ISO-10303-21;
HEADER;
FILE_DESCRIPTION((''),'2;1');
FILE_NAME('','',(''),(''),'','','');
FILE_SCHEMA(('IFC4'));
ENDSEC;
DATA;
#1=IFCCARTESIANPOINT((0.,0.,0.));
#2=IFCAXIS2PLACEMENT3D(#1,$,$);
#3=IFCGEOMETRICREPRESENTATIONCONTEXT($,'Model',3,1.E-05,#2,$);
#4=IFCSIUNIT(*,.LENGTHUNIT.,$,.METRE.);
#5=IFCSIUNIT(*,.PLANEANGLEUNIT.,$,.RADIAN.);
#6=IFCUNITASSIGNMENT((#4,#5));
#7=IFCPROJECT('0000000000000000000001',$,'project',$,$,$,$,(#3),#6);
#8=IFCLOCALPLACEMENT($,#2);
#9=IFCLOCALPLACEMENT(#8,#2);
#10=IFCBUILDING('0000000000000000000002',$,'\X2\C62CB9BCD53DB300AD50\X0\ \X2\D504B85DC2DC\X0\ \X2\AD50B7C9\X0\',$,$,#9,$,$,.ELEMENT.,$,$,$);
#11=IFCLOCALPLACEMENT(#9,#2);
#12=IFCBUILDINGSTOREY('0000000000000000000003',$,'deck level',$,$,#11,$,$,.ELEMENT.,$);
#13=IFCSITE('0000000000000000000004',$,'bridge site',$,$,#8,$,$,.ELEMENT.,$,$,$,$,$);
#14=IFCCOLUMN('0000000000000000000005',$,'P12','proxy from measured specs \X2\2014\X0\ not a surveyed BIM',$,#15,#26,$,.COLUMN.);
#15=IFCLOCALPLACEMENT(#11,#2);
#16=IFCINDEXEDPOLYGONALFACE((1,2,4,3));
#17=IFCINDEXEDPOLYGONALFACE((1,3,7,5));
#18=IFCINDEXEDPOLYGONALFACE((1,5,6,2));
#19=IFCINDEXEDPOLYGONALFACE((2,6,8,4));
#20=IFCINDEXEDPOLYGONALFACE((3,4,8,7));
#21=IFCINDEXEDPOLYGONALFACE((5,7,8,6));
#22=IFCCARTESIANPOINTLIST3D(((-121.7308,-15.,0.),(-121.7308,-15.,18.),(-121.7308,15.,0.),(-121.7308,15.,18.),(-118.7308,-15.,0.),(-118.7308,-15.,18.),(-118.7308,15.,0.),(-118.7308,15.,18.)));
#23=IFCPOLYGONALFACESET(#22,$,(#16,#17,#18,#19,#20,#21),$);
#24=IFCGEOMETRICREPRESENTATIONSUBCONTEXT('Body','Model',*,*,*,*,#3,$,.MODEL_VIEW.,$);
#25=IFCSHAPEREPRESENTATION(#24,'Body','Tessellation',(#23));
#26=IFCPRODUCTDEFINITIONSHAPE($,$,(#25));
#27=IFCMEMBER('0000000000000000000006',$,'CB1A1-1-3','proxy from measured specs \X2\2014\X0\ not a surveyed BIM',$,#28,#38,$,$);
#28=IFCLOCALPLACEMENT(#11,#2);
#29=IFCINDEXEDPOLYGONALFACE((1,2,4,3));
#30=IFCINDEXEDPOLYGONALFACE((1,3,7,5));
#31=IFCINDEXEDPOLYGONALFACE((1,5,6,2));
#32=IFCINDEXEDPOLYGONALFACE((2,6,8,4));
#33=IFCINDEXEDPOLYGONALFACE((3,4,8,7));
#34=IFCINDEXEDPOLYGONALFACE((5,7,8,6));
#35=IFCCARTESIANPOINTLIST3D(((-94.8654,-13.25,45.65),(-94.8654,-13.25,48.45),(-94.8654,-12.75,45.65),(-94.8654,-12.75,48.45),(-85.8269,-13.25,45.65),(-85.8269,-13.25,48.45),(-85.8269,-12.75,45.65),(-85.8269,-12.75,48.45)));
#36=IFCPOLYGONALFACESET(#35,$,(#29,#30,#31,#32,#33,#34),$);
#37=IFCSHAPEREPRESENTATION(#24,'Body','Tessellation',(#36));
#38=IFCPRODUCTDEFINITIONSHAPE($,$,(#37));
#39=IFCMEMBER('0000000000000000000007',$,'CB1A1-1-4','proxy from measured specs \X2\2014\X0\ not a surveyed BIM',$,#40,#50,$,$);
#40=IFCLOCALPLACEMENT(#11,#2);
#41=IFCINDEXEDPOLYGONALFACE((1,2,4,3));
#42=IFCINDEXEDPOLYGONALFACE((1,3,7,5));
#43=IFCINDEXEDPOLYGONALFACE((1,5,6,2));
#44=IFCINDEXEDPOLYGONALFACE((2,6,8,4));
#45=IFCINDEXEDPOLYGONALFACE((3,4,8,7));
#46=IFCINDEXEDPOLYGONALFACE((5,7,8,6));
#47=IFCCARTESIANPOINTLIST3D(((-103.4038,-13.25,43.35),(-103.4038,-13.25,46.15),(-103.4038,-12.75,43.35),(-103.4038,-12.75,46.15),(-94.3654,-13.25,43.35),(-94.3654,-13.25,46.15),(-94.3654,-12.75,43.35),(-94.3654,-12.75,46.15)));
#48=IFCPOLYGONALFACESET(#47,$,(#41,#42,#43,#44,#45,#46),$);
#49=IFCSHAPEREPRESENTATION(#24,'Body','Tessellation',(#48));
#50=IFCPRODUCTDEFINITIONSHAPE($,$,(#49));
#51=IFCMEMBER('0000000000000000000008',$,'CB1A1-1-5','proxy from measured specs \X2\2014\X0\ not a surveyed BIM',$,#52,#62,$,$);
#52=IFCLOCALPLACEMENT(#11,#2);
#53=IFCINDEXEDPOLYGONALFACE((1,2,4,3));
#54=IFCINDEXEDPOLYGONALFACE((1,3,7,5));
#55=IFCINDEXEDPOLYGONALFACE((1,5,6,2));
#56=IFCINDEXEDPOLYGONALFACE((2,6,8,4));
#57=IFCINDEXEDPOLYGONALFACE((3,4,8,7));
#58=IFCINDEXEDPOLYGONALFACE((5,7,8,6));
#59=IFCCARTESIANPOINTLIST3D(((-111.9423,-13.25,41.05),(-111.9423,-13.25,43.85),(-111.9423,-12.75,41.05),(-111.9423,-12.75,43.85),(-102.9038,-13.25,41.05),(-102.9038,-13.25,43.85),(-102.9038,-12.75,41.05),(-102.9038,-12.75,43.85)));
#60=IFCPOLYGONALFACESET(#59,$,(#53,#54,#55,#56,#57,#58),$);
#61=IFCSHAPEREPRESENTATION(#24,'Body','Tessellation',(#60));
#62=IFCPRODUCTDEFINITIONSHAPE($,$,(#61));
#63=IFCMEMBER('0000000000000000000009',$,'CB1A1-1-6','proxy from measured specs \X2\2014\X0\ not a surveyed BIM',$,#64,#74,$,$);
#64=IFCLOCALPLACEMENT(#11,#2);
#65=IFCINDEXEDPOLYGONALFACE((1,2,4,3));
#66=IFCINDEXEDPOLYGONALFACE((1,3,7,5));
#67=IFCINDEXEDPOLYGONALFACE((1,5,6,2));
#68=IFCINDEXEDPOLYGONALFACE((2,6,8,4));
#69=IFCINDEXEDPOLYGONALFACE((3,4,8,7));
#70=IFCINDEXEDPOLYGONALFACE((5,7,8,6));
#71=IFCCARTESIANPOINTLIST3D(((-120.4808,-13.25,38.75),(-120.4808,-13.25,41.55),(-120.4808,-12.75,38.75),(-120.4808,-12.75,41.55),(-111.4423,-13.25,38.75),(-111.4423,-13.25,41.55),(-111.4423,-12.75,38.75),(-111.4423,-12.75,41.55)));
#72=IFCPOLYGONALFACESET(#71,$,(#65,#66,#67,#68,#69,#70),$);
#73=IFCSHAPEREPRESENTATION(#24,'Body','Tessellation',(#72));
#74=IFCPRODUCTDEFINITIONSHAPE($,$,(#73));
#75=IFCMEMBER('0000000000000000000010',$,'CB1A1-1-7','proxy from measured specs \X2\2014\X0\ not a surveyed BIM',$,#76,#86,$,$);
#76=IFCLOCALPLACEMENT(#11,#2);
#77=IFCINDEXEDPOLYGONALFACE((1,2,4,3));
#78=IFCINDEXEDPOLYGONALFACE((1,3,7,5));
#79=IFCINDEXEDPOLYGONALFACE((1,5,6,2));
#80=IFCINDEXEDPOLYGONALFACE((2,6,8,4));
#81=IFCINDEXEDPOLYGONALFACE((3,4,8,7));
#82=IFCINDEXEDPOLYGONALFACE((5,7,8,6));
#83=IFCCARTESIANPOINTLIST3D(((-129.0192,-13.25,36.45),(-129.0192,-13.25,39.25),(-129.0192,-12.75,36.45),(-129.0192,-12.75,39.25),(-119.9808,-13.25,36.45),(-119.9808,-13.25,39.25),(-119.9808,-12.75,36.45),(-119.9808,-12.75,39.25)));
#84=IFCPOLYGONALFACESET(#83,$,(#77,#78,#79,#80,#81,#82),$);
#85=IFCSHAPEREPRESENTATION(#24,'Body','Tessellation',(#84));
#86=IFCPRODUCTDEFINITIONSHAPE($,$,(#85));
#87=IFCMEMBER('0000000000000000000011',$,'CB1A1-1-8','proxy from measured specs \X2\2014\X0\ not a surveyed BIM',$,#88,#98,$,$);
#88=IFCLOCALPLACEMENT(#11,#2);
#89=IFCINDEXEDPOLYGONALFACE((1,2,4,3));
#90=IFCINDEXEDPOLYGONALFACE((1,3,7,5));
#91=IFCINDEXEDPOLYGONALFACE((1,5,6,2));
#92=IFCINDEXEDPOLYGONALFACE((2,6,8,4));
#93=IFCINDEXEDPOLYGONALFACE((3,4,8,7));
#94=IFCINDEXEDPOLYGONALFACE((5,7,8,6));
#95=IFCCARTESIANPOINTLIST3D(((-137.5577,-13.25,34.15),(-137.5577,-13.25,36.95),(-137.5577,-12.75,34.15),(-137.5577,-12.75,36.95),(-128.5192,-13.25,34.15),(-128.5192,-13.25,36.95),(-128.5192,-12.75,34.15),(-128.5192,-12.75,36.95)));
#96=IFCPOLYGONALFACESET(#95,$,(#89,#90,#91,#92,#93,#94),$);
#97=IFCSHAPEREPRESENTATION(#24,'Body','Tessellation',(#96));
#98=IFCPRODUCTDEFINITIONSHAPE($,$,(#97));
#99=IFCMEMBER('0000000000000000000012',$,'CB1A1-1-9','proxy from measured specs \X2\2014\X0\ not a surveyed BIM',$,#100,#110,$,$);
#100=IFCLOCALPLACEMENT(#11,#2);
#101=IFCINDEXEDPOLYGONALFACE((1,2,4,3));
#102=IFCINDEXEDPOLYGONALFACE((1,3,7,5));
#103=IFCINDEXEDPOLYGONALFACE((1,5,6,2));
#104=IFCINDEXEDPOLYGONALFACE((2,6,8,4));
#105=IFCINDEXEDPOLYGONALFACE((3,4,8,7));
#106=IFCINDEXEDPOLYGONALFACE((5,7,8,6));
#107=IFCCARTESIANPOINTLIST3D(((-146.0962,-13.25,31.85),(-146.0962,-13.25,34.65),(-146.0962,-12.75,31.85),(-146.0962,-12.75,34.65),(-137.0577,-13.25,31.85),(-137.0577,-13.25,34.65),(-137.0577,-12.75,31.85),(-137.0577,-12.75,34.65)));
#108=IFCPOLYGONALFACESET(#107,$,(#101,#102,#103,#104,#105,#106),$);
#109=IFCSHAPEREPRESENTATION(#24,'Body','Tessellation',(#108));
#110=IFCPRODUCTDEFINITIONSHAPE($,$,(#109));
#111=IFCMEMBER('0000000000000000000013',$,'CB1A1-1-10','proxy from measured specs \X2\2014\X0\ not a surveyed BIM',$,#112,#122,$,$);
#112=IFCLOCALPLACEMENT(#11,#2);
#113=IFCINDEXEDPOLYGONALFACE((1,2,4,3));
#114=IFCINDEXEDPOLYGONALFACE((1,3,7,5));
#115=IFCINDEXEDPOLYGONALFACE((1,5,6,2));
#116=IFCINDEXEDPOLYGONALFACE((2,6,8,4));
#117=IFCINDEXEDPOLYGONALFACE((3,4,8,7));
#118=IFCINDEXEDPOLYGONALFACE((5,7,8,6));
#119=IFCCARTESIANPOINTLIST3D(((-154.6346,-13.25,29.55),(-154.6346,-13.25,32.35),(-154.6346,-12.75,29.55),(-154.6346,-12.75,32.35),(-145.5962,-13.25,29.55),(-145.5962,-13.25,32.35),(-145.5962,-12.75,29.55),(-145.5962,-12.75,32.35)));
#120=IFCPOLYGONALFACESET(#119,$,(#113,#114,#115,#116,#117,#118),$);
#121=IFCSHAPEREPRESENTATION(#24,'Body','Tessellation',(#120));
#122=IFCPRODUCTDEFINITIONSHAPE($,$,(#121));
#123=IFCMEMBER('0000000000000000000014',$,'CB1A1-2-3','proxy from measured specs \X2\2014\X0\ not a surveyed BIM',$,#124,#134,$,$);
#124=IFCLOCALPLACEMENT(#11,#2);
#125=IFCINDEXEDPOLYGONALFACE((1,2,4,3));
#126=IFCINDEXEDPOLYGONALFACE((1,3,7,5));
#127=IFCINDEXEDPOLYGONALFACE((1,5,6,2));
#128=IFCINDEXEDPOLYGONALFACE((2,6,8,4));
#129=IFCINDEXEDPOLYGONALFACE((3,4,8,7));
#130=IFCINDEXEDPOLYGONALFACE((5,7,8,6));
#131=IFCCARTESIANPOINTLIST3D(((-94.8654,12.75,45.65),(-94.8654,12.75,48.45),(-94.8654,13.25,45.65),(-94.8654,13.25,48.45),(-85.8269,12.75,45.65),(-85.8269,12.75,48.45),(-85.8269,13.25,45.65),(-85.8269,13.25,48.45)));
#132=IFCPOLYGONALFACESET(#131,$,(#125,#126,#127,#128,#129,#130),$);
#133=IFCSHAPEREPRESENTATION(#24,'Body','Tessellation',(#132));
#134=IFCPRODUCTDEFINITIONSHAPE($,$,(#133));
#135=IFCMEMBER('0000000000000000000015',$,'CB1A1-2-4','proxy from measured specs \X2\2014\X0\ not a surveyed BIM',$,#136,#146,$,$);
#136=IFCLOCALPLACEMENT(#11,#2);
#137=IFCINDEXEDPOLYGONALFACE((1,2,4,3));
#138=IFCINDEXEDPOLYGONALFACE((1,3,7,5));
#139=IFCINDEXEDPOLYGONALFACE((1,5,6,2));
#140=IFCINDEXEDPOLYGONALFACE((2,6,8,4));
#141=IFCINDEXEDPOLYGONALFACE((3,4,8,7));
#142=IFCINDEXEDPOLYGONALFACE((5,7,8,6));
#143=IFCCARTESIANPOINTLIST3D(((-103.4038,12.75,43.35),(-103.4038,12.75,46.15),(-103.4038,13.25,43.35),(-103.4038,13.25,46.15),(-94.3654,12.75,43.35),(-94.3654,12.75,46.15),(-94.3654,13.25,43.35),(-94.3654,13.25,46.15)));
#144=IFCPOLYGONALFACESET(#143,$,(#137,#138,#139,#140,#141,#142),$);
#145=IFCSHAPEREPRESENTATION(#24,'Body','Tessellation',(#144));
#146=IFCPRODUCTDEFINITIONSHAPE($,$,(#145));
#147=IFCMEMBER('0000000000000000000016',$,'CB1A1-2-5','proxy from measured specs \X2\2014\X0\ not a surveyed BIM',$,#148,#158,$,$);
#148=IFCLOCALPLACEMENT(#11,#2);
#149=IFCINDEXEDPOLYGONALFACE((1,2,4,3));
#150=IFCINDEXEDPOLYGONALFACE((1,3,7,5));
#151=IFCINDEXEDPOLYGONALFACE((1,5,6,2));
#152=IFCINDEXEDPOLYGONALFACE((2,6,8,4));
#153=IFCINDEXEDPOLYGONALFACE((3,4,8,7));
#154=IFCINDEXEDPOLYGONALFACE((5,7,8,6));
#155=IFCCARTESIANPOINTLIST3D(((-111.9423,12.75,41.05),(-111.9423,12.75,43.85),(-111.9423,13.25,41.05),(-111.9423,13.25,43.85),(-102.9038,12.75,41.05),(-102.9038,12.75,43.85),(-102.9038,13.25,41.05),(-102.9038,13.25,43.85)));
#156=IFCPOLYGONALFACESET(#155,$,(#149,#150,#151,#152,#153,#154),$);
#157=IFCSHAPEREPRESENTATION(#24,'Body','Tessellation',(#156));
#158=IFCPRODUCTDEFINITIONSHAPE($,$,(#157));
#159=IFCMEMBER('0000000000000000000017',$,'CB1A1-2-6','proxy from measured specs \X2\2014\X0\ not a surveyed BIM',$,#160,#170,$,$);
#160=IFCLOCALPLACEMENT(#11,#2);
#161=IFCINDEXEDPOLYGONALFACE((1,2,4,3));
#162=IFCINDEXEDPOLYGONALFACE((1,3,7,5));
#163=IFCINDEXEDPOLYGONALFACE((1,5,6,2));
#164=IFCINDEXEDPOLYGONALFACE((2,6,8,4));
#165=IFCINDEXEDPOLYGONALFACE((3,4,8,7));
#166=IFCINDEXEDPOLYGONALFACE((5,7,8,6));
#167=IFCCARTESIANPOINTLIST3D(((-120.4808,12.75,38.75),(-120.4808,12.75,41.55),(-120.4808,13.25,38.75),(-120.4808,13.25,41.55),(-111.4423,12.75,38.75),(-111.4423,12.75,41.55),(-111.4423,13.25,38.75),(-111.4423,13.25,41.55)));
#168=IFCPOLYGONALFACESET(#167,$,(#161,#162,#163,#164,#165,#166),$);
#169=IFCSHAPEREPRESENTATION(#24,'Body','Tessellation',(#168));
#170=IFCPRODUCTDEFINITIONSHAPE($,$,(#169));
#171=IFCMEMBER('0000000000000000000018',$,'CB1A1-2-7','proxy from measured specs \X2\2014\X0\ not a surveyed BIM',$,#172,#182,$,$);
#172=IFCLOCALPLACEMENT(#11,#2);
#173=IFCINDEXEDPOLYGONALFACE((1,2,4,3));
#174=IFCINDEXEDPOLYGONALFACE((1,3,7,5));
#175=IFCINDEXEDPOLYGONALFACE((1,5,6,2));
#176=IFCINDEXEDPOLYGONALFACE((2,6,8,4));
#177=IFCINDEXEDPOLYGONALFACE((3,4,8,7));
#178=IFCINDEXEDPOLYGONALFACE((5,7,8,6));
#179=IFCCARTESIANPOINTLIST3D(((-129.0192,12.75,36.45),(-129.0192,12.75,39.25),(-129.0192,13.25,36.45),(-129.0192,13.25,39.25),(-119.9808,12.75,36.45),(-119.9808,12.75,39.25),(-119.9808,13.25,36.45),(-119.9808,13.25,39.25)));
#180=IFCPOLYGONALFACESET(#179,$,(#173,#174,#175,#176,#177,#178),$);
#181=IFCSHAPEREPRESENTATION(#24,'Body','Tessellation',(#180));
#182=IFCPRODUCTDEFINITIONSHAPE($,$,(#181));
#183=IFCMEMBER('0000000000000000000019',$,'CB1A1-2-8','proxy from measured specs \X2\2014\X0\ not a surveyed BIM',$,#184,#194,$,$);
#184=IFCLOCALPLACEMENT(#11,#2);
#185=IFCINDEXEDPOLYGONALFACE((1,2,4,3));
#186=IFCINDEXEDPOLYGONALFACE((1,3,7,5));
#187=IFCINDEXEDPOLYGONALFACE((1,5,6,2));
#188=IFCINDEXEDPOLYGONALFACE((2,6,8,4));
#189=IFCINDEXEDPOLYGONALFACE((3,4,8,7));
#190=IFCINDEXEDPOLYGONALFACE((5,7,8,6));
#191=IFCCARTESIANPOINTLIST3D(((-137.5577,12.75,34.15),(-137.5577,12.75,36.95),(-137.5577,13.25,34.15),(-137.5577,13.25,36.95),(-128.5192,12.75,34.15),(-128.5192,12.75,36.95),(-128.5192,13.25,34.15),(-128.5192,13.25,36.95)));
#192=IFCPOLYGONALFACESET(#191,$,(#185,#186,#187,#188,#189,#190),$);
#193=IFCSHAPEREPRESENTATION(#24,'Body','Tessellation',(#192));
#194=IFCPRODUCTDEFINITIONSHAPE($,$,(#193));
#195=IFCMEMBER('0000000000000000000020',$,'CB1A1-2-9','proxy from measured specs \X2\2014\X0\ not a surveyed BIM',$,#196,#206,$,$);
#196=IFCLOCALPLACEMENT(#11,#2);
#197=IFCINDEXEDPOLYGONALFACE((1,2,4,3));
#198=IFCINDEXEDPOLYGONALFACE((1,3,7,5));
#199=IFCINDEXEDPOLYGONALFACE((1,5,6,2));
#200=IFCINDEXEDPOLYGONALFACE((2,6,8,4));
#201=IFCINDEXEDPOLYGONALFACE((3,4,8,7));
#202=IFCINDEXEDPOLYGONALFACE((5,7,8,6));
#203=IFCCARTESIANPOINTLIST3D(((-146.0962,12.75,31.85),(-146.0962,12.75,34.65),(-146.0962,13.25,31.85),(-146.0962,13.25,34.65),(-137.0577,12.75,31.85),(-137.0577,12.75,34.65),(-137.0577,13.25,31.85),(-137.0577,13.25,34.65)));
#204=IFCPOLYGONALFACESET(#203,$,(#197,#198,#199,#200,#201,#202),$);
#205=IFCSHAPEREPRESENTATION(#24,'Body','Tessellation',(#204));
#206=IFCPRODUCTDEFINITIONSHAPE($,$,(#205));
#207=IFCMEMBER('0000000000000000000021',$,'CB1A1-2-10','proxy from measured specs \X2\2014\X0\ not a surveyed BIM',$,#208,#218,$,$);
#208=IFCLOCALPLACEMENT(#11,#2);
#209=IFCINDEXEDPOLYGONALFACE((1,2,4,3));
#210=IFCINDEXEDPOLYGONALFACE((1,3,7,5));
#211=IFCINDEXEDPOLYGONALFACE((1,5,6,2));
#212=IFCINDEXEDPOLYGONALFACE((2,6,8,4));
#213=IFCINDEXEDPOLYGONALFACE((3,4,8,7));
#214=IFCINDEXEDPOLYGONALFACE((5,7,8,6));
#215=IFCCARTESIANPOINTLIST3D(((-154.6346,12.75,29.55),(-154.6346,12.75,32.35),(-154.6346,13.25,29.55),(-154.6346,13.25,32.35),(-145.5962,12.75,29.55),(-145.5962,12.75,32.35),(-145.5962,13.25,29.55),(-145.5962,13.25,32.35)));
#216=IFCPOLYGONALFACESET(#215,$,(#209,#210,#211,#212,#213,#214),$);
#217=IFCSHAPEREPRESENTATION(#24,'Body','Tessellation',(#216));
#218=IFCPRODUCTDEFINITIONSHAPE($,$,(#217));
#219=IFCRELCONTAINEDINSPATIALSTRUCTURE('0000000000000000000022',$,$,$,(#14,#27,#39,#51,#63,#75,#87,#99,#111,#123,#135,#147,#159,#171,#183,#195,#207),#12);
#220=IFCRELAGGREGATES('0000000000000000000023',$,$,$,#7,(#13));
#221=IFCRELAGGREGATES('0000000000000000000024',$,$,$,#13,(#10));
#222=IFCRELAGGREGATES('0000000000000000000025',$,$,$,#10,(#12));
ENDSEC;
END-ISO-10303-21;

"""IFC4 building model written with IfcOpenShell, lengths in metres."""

from ifc_helpers import new_model, si_unit, frame, origin, origin_2d, place, context, subcontext, project, spatial, rectangle, extrude, element, save


model = new_model("IFC4")

# Units and contexts
model_context = context("Model", 3, precision=1e-05, world=origin())
body_context = subcontext(model_context, "Body", "Model", "MODEL_VIEW")
ifc_project = project(units=[si_unit("LENGTHUNIT", "METRE"), si_unit("PLANEANGLEUNIT", "RADIAN")], contexts=[model_context])

# Site, building, storey
site_placement = place(None, origin())
site = spatial("IfcSite", under=ifc_project, at=site_placement, Name="bridge site", CompositionType="ELEMENT")
building_placement = place(site_placement, origin())
building = spatial("IfcBuilding", under=site, at=building_placement, Name="올림픽대교 프록시 교량", CompositionType="ELEMENT")
storey_placement = place(building_placement, origin())
storey = spatial("IfcBuildingStorey", under=building, at=storey_placement, Name="deck level", CompositionType="ELEMENT")

# Column
column_placement = place(storey_placement, frame((-120.2308, 0.0, 0.0)))
element("IfcColumn", 1, at=column_placement, inside=storey, Name="P12", Description="proxy from measured specs — not a surveyed BIM", PredefinedType="COLUMN", context=body_context, shape_type="SweptSolid", body=[
    extrude(rectangle(XDim=3.0, YDim=30.0, at=origin_2d()), origin(), (0.0, 0.0, 1.0), 18.0),
])

# Members
member_1_placement = place(storey_placement, frame((-90.3462, -13.0, 45.65)))
element("IfcMember", 2, at=member_1_placement, inside=storey, Name="CB1A1-1-3", Description="proxy from measured specs — not a surveyed BIM", context=body_context, shape_type="SweptSolid", body=[
    extrude(rectangle(XDim=9.0385, YDim=0.5, at=origin_2d()), origin(), (0.0, 0.0, 1.0), 2.8),
])
member_2_placement = place(storey_placement, frame((-98.8846, -13.0, 43.35)))
element("IfcMember", 3, at=member_2_placement, inside=storey, Name="CB1A1-1-4", Description="proxy from measured specs — not a surveyed BIM", context=body_context, shape_type="SweptSolid", body=[
    extrude(rectangle(XDim=9.0385, YDim=0.5, at=origin_2d()), origin(), (0.0, 0.0, 1.0), 2.8),
])
member_3_placement = place(storey_placement, frame((-107.4231, -13.0, 41.05)))
element("IfcMember", 4, at=member_3_placement, inside=storey, Name="CB1A1-1-5", Description="proxy from measured specs — not a surveyed BIM", context=body_context, shape_type="SweptSolid", body=[
    extrude(rectangle(XDim=9.0385, YDim=0.5, at=origin_2d()), origin(), (0.0, 0.0, 1.0), 2.8),
])
for number, where, name in (
    (5, (-115.9615, -13.0, 38.75), "CB1A1-1-6"),
    (6, (-124.5, -13.0, 36.45), "CB1A1-1-7"),
):
    element("IfcMember", number, at=place(storey_placement, frame(where)), inside=storey, Name=name, Description="proxy from measured specs — not a surveyed BIM", context=body_context, shape_type="SweptSolid", body=[
        extrude(rectangle(XDim=9.0385, YDim=0.5, at=origin_2d()), origin(), (0.0, 0.0, 1.0), 2.8),
    ])
member_4_placement = place(storey_placement, frame((-133.0385, -13.0, 34.15)))
element("IfcMember", 7, at=member_4_placement, inside=storey, Name="CB1A1-1-8", Description="proxy from measured specs — not a surveyed BIM", context=body_context, shape_type="SweptSolid", body=[
    extrude(rectangle(XDim=9.0385, YDim=0.5, at=origin_2d()), origin(), (0.0, 0.0, 1.0), 2.8),
])
member_5_placement = place(storey_placement, frame((-141.5769, -13.0, 31.85)))
element("IfcMember", 8, at=member_5_placement, inside=storey, Name="CB1A1-1-9", Description="proxy from measured specs — not a surveyed BIM", context=body_context, shape_type="SweptSolid", body=[
    extrude(rectangle(XDim=9.0385, YDim=0.5, at=origin_2d()), origin(), (0.0, 0.0, 1.0), 2.8),
])
member_6_placement = place(storey_placement, frame((-150.1154, -13.0, 29.55)))
element("IfcMember", 9, at=member_6_placement, inside=storey, Name="CB1A1-1-10", Description="proxy from measured specs — not a surveyed BIM", context=body_context, shape_type="SweptSolid", body=[
    extrude(rectangle(XDim=9.0385, YDim=0.5, at=origin_2d()), origin(), (0.0, 0.0, 1.0), 2.8),
])
member_7_placement = place(storey_placement, frame((-90.3462, 13.0, 45.65)))
element("IfcMember", 10, at=member_7_placement, inside=storey, Name="CB1A1-2-3", Description="proxy from measured specs — not a surveyed BIM", context=body_context, shape_type="SweptSolid", body=[
    extrude(rectangle(XDim=9.0385, YDim=0.5, at=origin_2d()), origin(), (0.0, 0.0, 1.0), 2.8),
])
member_8_placement = place(storey_placement, frame((-98.8846, 13.0, 43.35)))
element("IfcMember", 11, at=member_8_placement, inside=storey, Name="CB1A1-2-4", Description="proxy from measured specs — not a surveyed BIM", context=body_context, shape_type="SweptSolid", body=[
    extrude(rectangle(XDim=9.0385, YDim=0.5, at=origin_2d()), origin(), (0.0, 0.0, 1.0), 2.8),
])
member_9_placement = place(storey_placement, frame((-107.4231, 13.0, 41.05)))
element("IfcMember", 12, at=member_9_placement, inside=storey, Name="CB1A1-2-5", Description="proxy from measured specs — not a surveyed BIM", context=body_context, shape_type="SweptSolid", body=[
    extrude(rectangle(XDim=9.0385, YDim=0.5, at=origin_2d()), origin(), (0.0, 0.0, 1.0), 2.8),
])
for number, where, name in (
    (13, (-115.9615, 13.0, 38.75), "CB1A1-2-6"),
    (14, (-124.5, 13.0, 36.45), "CB1A1-2-7"),
):
    element("IfcMember", number, at=place(storey_placement, frame(where)), inside=storey, Name=name, Description="proxy from measured specs — not a surveyed BIM", context=body_context, shape_type="SweptSolid", body=[
        extrude(rectangle(XDim=9.0385, YDim=0.5, at=origin_2d()), origin(), (0.0, 0.0, 1.0), 2.8),
    ])
member_10_placement = place(storey_placement, frame((-133.0385, 13.0, 34.15)))
element("IfcMember", 15, at=member_10_placement, inside=storey, Name="CB1A1-2-8", Description="proxy from measured specs — not a surveyed BIM", context=body_context, shape_type="SweptSolid", body=[
    extrude(rectangle(XDim=9.0385, YDim=0.5, at=origin_2d()), origin(), (0.0, 0.0, 1.0), 2.8),
])
member_11_placement = place(storey_placement, frame((-141.5769, 13.0, 31.85)))
element("IfcMember", 16, at=member_11_placement, inside=storey, Name="CB1A1-2-9", Description="proxy from measured specs — not a surveyed BIM", context=body_context, shape_type="SweptSolid", body=[
    extrude(rectangle(XDim=9.0385, YDim=0.5, at=origin_2d()), origin(), (0.0, 0.0, 1.0), 2.8),
])
member_12_placement = place(storey_placement, frame((-150.1154, 13.0, 29.55)))
element("IfcMember", 17, at=member_12_placement, inside=storey, Name="CB1A1-2-10", Description="proxy from measured specs — not a surveyed BIM", context=body_context, shape_type="SweptSolid", body=[
    extrude(rectangle(XDim=9.0385, YDim=0.5, at=origin_2d()), origin(), (0.0, 0.0, 1.0), 2.8),
])

save(model, "model.ifc")
